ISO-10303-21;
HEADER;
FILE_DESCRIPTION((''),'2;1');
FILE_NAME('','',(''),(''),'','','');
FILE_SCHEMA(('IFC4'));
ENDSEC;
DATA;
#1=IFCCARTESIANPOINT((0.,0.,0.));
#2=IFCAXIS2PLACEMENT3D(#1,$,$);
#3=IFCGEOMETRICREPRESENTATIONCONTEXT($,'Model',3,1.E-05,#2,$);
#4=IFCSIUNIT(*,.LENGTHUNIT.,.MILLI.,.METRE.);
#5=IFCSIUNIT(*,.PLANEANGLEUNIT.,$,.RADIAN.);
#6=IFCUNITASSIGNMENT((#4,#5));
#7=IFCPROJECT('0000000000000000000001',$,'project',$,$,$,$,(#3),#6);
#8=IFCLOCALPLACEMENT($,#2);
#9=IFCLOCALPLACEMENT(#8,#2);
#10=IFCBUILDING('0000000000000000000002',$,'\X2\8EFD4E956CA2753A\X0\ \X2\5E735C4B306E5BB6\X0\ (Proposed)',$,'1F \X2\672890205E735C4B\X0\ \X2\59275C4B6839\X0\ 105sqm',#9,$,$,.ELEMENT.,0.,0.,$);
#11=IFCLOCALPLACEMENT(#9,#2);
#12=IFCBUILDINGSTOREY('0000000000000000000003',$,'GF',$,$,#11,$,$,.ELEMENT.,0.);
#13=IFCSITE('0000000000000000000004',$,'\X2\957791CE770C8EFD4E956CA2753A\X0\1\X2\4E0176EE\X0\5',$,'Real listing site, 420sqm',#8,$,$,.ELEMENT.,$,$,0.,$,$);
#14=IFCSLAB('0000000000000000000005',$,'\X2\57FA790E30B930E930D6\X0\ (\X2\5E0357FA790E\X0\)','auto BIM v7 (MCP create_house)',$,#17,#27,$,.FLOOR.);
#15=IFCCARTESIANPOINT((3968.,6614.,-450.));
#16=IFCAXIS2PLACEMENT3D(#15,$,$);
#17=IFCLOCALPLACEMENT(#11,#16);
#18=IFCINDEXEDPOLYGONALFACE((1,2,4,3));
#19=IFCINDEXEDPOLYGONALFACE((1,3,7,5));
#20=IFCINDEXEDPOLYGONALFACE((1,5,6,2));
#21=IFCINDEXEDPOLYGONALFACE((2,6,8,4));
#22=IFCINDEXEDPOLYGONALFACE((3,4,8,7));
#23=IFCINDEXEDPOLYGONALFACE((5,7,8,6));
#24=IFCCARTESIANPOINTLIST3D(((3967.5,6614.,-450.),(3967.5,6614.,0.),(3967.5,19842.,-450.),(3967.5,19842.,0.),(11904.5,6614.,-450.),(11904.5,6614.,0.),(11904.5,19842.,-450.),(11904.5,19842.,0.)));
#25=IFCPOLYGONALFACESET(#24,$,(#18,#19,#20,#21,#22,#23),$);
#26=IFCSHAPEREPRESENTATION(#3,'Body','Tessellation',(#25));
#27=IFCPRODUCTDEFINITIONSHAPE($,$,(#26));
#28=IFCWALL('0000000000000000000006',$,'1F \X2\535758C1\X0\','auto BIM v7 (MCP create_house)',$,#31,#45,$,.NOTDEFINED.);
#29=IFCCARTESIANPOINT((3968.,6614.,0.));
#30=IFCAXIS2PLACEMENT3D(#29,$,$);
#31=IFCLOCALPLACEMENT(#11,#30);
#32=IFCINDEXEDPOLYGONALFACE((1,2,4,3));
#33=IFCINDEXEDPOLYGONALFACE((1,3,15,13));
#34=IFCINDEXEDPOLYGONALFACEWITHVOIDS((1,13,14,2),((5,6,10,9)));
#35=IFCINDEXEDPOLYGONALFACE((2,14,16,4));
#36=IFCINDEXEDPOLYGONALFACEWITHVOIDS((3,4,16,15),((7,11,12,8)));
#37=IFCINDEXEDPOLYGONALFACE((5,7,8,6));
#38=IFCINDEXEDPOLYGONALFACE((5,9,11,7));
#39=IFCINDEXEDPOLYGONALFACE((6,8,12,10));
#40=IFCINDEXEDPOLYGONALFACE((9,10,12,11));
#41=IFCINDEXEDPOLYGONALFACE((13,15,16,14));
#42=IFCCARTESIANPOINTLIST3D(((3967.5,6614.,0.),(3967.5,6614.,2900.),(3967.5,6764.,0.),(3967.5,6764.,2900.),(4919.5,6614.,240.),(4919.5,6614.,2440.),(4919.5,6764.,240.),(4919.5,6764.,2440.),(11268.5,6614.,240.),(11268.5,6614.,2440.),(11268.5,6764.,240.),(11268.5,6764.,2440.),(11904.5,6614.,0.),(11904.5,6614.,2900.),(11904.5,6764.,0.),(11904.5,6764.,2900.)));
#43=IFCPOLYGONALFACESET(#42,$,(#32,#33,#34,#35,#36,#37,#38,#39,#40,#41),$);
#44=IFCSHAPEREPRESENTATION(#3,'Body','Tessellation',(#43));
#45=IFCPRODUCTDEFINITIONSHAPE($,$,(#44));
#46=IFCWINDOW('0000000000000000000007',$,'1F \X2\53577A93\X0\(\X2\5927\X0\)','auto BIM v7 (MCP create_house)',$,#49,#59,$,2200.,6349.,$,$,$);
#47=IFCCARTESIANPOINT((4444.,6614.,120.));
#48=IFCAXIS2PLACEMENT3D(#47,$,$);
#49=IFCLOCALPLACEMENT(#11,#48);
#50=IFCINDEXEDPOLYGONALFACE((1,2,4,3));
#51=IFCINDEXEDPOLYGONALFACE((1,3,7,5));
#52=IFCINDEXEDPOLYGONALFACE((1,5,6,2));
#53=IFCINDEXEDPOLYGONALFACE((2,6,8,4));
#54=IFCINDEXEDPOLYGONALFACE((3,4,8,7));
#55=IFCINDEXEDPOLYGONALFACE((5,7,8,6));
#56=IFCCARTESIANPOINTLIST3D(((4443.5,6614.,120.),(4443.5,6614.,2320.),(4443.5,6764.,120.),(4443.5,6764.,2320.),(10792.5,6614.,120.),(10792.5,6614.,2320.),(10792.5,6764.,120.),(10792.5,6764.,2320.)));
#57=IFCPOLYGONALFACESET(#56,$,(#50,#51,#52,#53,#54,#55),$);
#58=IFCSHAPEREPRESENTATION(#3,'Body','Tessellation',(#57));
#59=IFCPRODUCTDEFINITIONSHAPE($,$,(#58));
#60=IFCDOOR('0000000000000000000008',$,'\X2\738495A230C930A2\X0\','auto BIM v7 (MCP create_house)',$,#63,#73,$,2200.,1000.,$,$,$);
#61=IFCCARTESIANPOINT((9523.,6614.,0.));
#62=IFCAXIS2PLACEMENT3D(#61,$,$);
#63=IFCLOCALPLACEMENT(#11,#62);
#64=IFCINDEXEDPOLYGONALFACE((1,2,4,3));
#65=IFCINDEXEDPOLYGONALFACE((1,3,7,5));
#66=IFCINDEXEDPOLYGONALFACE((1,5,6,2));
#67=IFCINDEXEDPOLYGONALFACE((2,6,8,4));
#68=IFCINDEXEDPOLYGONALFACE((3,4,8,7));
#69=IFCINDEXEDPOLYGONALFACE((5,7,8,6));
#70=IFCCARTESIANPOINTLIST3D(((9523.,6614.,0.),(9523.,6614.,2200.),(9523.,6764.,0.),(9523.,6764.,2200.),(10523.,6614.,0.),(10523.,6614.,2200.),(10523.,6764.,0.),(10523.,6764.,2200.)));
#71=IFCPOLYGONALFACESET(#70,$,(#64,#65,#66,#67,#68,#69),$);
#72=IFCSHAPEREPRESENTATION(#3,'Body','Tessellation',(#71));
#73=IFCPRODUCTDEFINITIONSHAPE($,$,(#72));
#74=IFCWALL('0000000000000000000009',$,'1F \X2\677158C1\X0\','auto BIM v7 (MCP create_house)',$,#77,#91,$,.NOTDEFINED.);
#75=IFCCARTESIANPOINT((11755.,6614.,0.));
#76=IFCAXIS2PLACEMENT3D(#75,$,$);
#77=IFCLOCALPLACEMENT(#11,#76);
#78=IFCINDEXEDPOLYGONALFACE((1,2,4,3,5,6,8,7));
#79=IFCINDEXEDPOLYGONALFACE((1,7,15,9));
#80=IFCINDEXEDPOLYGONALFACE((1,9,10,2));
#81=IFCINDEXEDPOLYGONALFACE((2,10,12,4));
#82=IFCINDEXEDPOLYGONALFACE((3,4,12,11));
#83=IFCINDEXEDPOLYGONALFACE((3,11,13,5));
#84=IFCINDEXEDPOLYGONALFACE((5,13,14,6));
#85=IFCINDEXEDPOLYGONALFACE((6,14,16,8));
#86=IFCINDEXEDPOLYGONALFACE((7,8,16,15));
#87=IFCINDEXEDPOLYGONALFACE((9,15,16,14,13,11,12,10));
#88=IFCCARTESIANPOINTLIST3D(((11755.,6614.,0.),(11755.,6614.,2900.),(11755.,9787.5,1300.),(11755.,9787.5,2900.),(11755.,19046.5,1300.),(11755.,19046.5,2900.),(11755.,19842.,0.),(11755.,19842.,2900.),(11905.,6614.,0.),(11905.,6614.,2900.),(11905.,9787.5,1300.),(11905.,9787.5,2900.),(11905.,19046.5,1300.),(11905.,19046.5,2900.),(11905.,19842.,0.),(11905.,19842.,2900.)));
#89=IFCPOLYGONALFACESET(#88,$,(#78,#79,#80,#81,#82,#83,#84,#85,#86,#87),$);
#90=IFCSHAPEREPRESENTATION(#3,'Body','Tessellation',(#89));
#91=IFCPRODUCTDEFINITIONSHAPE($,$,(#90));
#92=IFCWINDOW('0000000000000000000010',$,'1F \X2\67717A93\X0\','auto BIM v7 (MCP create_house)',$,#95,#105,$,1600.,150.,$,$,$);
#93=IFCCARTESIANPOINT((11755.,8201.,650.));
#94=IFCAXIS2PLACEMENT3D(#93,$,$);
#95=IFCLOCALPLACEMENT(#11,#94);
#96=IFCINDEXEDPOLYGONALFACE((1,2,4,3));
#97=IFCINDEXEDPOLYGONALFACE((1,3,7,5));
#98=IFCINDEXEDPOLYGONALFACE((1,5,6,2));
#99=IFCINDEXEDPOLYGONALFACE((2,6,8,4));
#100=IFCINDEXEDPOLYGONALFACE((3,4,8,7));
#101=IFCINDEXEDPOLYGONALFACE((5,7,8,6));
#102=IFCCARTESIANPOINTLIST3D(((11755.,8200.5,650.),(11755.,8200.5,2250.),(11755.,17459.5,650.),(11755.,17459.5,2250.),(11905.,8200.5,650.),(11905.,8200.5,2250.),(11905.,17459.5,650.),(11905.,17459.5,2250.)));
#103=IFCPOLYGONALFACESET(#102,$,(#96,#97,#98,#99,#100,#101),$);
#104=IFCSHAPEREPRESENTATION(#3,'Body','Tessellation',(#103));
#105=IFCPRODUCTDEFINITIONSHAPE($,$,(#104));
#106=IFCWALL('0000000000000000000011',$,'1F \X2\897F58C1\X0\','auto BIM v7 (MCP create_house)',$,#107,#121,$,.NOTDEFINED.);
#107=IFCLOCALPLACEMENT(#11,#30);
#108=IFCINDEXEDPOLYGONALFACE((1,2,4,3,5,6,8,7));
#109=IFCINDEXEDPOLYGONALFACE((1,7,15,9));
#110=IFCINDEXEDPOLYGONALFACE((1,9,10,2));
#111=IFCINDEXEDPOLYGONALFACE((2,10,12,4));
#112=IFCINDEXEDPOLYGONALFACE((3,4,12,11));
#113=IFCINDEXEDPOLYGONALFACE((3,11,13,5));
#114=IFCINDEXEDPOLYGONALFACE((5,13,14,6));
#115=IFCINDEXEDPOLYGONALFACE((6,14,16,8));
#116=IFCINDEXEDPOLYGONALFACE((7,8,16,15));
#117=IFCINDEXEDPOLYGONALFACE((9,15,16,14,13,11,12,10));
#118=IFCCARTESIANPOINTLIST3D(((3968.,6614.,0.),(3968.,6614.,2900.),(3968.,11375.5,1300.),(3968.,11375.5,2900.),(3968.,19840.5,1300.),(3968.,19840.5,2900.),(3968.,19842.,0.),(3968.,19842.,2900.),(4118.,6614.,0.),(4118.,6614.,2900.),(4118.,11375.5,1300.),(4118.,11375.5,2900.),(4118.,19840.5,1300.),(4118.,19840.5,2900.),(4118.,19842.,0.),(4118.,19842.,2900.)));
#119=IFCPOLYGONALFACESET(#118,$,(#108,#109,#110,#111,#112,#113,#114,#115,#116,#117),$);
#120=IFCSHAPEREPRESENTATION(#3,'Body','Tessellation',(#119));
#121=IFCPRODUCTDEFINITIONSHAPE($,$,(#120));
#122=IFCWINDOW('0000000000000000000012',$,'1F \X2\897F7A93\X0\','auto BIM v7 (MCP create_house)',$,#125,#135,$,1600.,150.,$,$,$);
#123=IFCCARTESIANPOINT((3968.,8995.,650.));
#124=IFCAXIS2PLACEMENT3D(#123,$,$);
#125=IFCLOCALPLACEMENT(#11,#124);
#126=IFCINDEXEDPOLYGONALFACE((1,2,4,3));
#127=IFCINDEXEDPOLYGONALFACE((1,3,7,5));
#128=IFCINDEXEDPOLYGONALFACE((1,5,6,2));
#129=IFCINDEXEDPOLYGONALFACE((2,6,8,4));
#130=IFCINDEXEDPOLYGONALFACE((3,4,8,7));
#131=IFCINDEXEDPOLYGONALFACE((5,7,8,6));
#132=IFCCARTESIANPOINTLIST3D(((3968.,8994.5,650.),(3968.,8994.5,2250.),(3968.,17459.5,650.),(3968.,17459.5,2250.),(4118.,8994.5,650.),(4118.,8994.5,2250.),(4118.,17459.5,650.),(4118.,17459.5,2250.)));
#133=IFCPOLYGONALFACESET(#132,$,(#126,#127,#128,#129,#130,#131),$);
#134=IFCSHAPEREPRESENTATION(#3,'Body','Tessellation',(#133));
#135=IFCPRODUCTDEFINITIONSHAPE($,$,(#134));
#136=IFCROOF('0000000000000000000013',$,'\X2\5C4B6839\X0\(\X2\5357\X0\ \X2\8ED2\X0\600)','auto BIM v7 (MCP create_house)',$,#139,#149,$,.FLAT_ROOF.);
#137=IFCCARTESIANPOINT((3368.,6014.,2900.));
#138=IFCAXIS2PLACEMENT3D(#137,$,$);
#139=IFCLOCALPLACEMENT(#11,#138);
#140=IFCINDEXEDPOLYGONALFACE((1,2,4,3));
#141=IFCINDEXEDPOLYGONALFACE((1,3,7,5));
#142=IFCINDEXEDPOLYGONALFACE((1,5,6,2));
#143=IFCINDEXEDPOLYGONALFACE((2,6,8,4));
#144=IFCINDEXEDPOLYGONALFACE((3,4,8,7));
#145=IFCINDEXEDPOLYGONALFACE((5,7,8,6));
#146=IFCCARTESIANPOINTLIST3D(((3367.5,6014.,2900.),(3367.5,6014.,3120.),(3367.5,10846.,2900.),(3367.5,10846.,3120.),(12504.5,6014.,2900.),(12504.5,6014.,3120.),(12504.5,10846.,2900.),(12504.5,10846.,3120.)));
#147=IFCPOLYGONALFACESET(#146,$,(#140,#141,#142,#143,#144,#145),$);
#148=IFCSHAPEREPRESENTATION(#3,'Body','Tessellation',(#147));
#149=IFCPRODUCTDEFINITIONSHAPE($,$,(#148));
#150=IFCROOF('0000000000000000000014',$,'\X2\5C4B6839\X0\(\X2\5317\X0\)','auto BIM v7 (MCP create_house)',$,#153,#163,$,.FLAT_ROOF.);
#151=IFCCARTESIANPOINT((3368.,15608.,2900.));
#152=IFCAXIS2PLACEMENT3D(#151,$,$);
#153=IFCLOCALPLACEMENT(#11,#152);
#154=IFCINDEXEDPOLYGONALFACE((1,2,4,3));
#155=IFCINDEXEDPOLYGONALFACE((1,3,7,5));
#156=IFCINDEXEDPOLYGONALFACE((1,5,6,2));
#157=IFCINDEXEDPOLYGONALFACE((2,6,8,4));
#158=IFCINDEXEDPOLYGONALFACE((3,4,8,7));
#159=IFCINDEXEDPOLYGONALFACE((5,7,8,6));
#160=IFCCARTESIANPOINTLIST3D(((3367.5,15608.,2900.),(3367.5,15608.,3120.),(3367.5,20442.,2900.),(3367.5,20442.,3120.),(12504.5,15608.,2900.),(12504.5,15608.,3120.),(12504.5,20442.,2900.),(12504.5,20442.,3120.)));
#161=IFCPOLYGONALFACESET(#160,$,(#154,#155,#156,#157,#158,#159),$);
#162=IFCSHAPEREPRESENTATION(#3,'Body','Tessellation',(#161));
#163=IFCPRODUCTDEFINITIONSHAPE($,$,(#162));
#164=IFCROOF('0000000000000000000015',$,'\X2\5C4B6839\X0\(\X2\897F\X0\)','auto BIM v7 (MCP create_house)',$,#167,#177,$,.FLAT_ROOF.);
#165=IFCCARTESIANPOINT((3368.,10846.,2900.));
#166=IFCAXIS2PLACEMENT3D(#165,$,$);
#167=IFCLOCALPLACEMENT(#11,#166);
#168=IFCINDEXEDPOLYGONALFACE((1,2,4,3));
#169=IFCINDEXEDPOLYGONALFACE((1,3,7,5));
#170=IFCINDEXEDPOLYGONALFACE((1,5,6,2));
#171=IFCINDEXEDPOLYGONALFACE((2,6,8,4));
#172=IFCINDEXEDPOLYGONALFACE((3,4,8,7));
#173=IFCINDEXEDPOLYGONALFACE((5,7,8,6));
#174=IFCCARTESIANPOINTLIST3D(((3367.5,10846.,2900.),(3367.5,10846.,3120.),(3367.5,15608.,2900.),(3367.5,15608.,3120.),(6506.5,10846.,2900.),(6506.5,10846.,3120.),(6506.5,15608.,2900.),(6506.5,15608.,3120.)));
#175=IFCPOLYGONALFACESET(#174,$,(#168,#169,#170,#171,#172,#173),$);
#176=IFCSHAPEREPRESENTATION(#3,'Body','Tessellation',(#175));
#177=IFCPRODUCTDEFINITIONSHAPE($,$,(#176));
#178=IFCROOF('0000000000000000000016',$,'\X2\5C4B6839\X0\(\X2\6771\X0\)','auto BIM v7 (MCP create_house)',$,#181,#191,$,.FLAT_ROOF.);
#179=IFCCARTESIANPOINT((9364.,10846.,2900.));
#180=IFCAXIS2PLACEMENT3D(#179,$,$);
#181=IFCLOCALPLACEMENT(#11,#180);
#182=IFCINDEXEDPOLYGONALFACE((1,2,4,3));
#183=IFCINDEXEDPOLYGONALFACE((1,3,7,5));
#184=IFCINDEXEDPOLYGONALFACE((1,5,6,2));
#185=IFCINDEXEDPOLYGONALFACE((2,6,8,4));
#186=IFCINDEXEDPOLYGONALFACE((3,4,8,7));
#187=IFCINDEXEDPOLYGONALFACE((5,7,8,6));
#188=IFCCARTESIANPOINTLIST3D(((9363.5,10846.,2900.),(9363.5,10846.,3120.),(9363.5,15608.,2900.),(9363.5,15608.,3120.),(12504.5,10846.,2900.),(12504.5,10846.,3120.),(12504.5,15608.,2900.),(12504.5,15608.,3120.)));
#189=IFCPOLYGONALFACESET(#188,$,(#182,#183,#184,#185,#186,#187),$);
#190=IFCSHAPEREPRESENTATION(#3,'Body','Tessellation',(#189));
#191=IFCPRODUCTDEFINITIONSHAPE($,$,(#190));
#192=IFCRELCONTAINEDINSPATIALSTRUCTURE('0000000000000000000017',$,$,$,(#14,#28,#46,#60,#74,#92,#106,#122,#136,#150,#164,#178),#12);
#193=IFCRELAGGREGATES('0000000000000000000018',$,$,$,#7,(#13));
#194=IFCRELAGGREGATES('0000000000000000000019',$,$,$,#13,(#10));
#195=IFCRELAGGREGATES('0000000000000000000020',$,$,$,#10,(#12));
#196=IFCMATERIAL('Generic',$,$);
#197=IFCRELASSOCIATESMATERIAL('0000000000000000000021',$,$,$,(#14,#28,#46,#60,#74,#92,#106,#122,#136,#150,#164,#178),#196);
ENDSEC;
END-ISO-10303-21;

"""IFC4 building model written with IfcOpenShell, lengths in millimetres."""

from ifc_helpers import new_model, si_unit, frame, frame_2d, origin, place, context, project, spatial, rectangle, extrude, material, element, fill, save


model = new_model("IFC4")

# Units and contexts
model_context = context("Model", 3, precision=1e-05, world=origin())
ifc_project = project(units=[si_unit("LENGTHUNIT", "METRE", prefix="MILLI"), si_unit("PLANEANGLEUNIT", "RADIAN")], contexts=[model_context])

# Site, building, storey
site_placement = place(None, origin())
site = spatial("IfcSite", under=ifc_project, at=site_placement, Name="長野県軽井沢町1丁目5", ObjectType="Real listing site, 420sqm", CompositionType="ELEMENT", RefElevation=0.0)
building_placement = place(site_placement, origin())
building = spatial("IfcBuilding", under=site, at=building_placement, Name="軽井沢町 平屋の家 (Proposed)", ObjectType="1F 木造平屋 大屋根 105sqm", CompositionType="ELEMENT", ElevationOfRefHeight=0.0, ElevationOfTerrain=0.0)
storey_placement = place(building_placement, origin())
storey = spatial("IfcBuildingStorey", under=building, at=storey_placement, Name="GF", CompositionType="ELEMENT", Elevation=0.0)

# Slab
ifc_material = material(Name="Generic")
slab_1_placement = place(storey_placement, frame((3968.0, 6614.0, -450.0)))
element("IfcSlab", 1, at=slab_1_placement, inside=storey, material=ifc_material, Name="基礎スラブ (布基礎)", Description="auto BIM v7 (MCP create_house)", PredefinedType="FLOOR", context=model_context, shape_type="SweptSolid", body=[
    extrude(rectangle(XDim=7937.0, YDim=13228.0, at=frame_2d((3968.0, 6614.0))), frame((3968.0, 6614.0, -450.0)), (0.0, 0.0, 1.0), 450.0),
])

# Wall, openings, window, door
wall_1_placement = place(storey_placement, frame((3968.0, 6614.0, 0.0)))
wall_1 = element("IfcWall", 2, at=wall_1_placement, inside=storey, material=ifc_material, Name="1F 南壁", Description="auto BIM v7 (MCP create_house)", PredefinedType="NOTDEFINED", context=model_context, shape_type="SweptSolid", body=[
    extrude(rectangle(XDim=7937.0, YDim=150.0, at=frame_2d((3968.0, 75.0))), frame((3968.0, 6614.0, 0.0)), (0.0, 0.0, 1.0), 2900.0),
])
opening_1_placement = place(storey_placement, frame((4444.0, 6614.0, 120.0)))
opening_1 = element("IfcOpeningElement", 3, at=opening_1_placement, cuts=wall_1, PredefinedType="NOTDEFINED", context=model_context, shape_type="SweptSolid", body=[
    extrude(rectangle(XDim=6349.0, YDim=150.0, at=frame_2d((3174.0, 75.0))), frame((4444.0, 6614.0, 120.0)), (0.0, 0.0, 1.0), 2200.0),
])
opening_2_placement = place(storey_placement, frame((9523.0, 6614.0, 0.0)))
opening_2 = element("IfcOpeningElement", 4, at=opening_2_placement, cuts=wall_1, PredefinedType="NOTDEFINED", context=model_context, shape_type="SweptSolid", body=[
    extrude(rectangle(XDim=1000.0, YDim=150.0, at=frame_2d((500.0, 75.0))), frame((9523.0, 6614.0, 0.0)), (0.0, 0.0, 1.0), 2200.0),
])
window_1_placement = place(storey_placement, frame((4444.0, 6614.0, 120.0)))
window_1 = element("IfcWindow", 5, at=window_1_placement, inside=storey, material=ifc_material, Name="1F 南窓(大)", Description="auto BIM v7 (MCP create_house)", OverallHeight=2200.0, OverallWidth=6349.0, context=model_context, shape_type="SweptSolid", body=[
    extrude(rectangle(XDim=6349.0, YDim=150.0, at=frame_2d((3174.0, 75.0))), frame((4444.0, 6614.0, 120.0)), (0.0, 0.0, 1.0), 2200.0),
])
fill(opening_1, window_1)
door_placement = place(storey_placement, frame((9523.0, 6614.0, 0.0)))
door = element("IfcDoor", 6, at=door_placement, inside=storey, material=ifc_material, Name="玄関ドア", Description="auto BIM v7 (MCP create_house)", OverallHeight=2200.0, OverallWidth=1000.0, context=model_context, shape_type="SweptSolid", body=[
    extrude(rectangle(XDim=1000.0, YDim=150.0, at=frame_2d((500.0, 75.0))), frame((9523.0, 6614.0, 0.0)), (0.0, 0.0, 1.0), 2200.0),
])
fill(opening_2, door)

# Walls, openings, windows
wall_2_placement = place(storey_placement, frame((11755.0, 6614.0, 0.0)))
wall_2 = element("IfcWall", 7, at=wall_2_placement, inside=storey, material=ifc_material, Name="1F 東壁", Description="auto BIM v7 (MCP create_house)", PredefinedType="NOTDEFINED", context=model_context, shape_type="SweptSolid", body=[
    extrude(rectangle(XDim=150.0, YDim=13228.0, at=frame_2d((75.0, 6614.0))), frame((11755.0, 6614.0, 0.0)), (0.0, 0.0, 1.0), 2900.0),
])
opening_3_placement = place(storey_placement, frame((11755.0, 8201.0, 650.0)))
opening_3 = element("IfcOpeningElement", 8, at=opening_3_placement, cuts=wall_2, PredefinedType="NOTDEFINED", context=model_context, shape_type="SweptSolid", body=[
    extrude(rectangle(XDim=150.0, YDim=9259.0, at=frame_2d((75.0, 4629.0))), frame((11755.0, 8201.0, 650.0)), (0.0, 0.0, 1.0), 1600.0),
])
window_2_placement = place(storey_placement, frame((11755.0, 8201.0, 650.0)))
window_2 = element("IfcWindow", 9, at=window_2_placement, inside=storey, material=ifc_material, Name="1F 東窓", Description="auto BIM v7 (MCP create_house)", OverallHeight=1600.0, OverallWidth=150.0, context=model_context, shape_type="SweptSolid", body=[
    extrude(rectangle(XDim=150.0, YDim=9259.0, at=frame_2d((75.0, 4629.0))), frame((11755.0, 8201.0, 650.0)), (0.0, 0.0, 1.0), 1600.0),
])
fill(opening_3, window_2)
wall_3_placement = place(storey_placement, frame((3968.0, 6614.0, 0.0)))
wall_3 = element("IfcWall", 10, at=wall_3_placement, inside=storey, material=ifc_material, Name="1F 西壁", Description="auto BIM v7 (MCP create_house)", PredefinedType="NOTDEFINED", context=model_context, shape_type="SweptSolid", body=[
    extrude(rectangle(XDim=150.0, YDim=13228.0, at=frame_2d((75.0, 6614.0))), frame((3968.0, 6614.0, 0.0)), (0.0, 0.0, 1.0), 2900.0),
])
opening_4_placement = place(storey_placement, frame((3968.0, 8995.0, 650.0)))
opening_4 = element("IfcOpeningElement", 11, at=opening_4_placement, cuts=wall_3, PredefinedType="NOTDEFINED", context=model_context, shape_type="SweptSolid", body=[
    extrude(rectangle(XDim=150.0, YDim=8465.0, at=frame_2d((75.0, 4232.0))), frame((3968.0, 8995.0, 650.0)), (0.0, 0.0, 1.0), 1600.0),
])
window_3_placement = place(storey_placement, frame((3968.0, 8995.0, 650.0)))
window_3 = element("IfcWindow", 12, at=window_3_placement, inside=storey, material=ifc_material, Name="1F 西窓", Description="auto BIM v7 (MCP create_house)", OverallHeight=1600.0, OverallWidth=150.0, context=model_context, shape_type="SweptSolid", body=[
    extrude(rectangle(XDim=150.0, YDim=8465.0, at=frame_2d((75.0, 4232.0))), frame((3968.0, 8995.0, 650.0)), (0.0, 0.0, 1.0), 1600.0),
])
fill(opening_4, window_3)

# Roofs
roof_1_placement = place(storey_placement, frame((3368.0, 6014.0, 2900.0)))
element("IfcRoof", 13, at=roof_1_placement, inside=storey, material=ifc_material, Name="屋根(南 軒600)", Description="auto BIM v7 (MCP create_house)", PredefinedType="FLAT_ROOF", context=model_context, shape_type="SweptSolid", body=[
    extrude(rectangle(XDim=9137.0, YDim=4832.0, at=frame_2d((4568.0, 2416.0))), frame((3368.0, 6014.0, 2900.0)), (0.0, 0.0, 1.0), 220.0),
])
roof_2_placement = place(storey_placement, frame((3368.0, 15608.0, 2900.0)))
element("IfcRoof", 14, at=roof_2_placement, inside=storey, material=ifc_material, Name="屋根(北)", Description="auto BIM v7 (MCP create_house)", PredefinedType="FLAT_ROOF", context=model_context, shape_type="SweptSolid", body=[
    extrude(rectangle(XDim=9137.0, YDim=4834.0, at=frame_2d((4568.0, 2417.0))), frame((3368.0, 15608.0, 2900.0)), (0.0, 0.0, 1.0), 220.0),
])
roof_3_placement = place(storey_placement, frame((3368.0, 10846.0, 2900.0)))
element("IfcRoof", 15, at=roof_3_placement, inside=storey, material=ifc_material, Name="屋根(西)", Description="auto BIM v7 (MCP create_house)", PredefinedType="FLAT_ROOF", context=model_context, shape_type="SweptSolid", body=[
    extrude(rectangle(XDim=3139.0, YDim=4762.0, at=frame_2d((1569.0, 2381.0))), frame((3368.0, 10846.0, 2900.0)), (0.0, 0.0, 1.0), 220.0),
])
roof_4_placement = place(storey_placement, frame((9364.0, 10846.0, 2900.0)))
element("IfcRoof", 16, at=roof_4_placement, inside=storey, material=ifc_material, Name="屋根(東)", Description="auto BIM v7 (MCP create_house)", PredefinedType="FLAT_ROOF", context=model_context, shape_type="SweptSolid", body=[
    extrude(rectangle(XDim=3141.0, YDim=4762.0, at=frame_2d((1570.0, 2381.0))), frame((9364.0, 10846.0, 2900.0)), (0.0, 0.0, 1.0), 220.0),
])

save(model, "model.ifc")
